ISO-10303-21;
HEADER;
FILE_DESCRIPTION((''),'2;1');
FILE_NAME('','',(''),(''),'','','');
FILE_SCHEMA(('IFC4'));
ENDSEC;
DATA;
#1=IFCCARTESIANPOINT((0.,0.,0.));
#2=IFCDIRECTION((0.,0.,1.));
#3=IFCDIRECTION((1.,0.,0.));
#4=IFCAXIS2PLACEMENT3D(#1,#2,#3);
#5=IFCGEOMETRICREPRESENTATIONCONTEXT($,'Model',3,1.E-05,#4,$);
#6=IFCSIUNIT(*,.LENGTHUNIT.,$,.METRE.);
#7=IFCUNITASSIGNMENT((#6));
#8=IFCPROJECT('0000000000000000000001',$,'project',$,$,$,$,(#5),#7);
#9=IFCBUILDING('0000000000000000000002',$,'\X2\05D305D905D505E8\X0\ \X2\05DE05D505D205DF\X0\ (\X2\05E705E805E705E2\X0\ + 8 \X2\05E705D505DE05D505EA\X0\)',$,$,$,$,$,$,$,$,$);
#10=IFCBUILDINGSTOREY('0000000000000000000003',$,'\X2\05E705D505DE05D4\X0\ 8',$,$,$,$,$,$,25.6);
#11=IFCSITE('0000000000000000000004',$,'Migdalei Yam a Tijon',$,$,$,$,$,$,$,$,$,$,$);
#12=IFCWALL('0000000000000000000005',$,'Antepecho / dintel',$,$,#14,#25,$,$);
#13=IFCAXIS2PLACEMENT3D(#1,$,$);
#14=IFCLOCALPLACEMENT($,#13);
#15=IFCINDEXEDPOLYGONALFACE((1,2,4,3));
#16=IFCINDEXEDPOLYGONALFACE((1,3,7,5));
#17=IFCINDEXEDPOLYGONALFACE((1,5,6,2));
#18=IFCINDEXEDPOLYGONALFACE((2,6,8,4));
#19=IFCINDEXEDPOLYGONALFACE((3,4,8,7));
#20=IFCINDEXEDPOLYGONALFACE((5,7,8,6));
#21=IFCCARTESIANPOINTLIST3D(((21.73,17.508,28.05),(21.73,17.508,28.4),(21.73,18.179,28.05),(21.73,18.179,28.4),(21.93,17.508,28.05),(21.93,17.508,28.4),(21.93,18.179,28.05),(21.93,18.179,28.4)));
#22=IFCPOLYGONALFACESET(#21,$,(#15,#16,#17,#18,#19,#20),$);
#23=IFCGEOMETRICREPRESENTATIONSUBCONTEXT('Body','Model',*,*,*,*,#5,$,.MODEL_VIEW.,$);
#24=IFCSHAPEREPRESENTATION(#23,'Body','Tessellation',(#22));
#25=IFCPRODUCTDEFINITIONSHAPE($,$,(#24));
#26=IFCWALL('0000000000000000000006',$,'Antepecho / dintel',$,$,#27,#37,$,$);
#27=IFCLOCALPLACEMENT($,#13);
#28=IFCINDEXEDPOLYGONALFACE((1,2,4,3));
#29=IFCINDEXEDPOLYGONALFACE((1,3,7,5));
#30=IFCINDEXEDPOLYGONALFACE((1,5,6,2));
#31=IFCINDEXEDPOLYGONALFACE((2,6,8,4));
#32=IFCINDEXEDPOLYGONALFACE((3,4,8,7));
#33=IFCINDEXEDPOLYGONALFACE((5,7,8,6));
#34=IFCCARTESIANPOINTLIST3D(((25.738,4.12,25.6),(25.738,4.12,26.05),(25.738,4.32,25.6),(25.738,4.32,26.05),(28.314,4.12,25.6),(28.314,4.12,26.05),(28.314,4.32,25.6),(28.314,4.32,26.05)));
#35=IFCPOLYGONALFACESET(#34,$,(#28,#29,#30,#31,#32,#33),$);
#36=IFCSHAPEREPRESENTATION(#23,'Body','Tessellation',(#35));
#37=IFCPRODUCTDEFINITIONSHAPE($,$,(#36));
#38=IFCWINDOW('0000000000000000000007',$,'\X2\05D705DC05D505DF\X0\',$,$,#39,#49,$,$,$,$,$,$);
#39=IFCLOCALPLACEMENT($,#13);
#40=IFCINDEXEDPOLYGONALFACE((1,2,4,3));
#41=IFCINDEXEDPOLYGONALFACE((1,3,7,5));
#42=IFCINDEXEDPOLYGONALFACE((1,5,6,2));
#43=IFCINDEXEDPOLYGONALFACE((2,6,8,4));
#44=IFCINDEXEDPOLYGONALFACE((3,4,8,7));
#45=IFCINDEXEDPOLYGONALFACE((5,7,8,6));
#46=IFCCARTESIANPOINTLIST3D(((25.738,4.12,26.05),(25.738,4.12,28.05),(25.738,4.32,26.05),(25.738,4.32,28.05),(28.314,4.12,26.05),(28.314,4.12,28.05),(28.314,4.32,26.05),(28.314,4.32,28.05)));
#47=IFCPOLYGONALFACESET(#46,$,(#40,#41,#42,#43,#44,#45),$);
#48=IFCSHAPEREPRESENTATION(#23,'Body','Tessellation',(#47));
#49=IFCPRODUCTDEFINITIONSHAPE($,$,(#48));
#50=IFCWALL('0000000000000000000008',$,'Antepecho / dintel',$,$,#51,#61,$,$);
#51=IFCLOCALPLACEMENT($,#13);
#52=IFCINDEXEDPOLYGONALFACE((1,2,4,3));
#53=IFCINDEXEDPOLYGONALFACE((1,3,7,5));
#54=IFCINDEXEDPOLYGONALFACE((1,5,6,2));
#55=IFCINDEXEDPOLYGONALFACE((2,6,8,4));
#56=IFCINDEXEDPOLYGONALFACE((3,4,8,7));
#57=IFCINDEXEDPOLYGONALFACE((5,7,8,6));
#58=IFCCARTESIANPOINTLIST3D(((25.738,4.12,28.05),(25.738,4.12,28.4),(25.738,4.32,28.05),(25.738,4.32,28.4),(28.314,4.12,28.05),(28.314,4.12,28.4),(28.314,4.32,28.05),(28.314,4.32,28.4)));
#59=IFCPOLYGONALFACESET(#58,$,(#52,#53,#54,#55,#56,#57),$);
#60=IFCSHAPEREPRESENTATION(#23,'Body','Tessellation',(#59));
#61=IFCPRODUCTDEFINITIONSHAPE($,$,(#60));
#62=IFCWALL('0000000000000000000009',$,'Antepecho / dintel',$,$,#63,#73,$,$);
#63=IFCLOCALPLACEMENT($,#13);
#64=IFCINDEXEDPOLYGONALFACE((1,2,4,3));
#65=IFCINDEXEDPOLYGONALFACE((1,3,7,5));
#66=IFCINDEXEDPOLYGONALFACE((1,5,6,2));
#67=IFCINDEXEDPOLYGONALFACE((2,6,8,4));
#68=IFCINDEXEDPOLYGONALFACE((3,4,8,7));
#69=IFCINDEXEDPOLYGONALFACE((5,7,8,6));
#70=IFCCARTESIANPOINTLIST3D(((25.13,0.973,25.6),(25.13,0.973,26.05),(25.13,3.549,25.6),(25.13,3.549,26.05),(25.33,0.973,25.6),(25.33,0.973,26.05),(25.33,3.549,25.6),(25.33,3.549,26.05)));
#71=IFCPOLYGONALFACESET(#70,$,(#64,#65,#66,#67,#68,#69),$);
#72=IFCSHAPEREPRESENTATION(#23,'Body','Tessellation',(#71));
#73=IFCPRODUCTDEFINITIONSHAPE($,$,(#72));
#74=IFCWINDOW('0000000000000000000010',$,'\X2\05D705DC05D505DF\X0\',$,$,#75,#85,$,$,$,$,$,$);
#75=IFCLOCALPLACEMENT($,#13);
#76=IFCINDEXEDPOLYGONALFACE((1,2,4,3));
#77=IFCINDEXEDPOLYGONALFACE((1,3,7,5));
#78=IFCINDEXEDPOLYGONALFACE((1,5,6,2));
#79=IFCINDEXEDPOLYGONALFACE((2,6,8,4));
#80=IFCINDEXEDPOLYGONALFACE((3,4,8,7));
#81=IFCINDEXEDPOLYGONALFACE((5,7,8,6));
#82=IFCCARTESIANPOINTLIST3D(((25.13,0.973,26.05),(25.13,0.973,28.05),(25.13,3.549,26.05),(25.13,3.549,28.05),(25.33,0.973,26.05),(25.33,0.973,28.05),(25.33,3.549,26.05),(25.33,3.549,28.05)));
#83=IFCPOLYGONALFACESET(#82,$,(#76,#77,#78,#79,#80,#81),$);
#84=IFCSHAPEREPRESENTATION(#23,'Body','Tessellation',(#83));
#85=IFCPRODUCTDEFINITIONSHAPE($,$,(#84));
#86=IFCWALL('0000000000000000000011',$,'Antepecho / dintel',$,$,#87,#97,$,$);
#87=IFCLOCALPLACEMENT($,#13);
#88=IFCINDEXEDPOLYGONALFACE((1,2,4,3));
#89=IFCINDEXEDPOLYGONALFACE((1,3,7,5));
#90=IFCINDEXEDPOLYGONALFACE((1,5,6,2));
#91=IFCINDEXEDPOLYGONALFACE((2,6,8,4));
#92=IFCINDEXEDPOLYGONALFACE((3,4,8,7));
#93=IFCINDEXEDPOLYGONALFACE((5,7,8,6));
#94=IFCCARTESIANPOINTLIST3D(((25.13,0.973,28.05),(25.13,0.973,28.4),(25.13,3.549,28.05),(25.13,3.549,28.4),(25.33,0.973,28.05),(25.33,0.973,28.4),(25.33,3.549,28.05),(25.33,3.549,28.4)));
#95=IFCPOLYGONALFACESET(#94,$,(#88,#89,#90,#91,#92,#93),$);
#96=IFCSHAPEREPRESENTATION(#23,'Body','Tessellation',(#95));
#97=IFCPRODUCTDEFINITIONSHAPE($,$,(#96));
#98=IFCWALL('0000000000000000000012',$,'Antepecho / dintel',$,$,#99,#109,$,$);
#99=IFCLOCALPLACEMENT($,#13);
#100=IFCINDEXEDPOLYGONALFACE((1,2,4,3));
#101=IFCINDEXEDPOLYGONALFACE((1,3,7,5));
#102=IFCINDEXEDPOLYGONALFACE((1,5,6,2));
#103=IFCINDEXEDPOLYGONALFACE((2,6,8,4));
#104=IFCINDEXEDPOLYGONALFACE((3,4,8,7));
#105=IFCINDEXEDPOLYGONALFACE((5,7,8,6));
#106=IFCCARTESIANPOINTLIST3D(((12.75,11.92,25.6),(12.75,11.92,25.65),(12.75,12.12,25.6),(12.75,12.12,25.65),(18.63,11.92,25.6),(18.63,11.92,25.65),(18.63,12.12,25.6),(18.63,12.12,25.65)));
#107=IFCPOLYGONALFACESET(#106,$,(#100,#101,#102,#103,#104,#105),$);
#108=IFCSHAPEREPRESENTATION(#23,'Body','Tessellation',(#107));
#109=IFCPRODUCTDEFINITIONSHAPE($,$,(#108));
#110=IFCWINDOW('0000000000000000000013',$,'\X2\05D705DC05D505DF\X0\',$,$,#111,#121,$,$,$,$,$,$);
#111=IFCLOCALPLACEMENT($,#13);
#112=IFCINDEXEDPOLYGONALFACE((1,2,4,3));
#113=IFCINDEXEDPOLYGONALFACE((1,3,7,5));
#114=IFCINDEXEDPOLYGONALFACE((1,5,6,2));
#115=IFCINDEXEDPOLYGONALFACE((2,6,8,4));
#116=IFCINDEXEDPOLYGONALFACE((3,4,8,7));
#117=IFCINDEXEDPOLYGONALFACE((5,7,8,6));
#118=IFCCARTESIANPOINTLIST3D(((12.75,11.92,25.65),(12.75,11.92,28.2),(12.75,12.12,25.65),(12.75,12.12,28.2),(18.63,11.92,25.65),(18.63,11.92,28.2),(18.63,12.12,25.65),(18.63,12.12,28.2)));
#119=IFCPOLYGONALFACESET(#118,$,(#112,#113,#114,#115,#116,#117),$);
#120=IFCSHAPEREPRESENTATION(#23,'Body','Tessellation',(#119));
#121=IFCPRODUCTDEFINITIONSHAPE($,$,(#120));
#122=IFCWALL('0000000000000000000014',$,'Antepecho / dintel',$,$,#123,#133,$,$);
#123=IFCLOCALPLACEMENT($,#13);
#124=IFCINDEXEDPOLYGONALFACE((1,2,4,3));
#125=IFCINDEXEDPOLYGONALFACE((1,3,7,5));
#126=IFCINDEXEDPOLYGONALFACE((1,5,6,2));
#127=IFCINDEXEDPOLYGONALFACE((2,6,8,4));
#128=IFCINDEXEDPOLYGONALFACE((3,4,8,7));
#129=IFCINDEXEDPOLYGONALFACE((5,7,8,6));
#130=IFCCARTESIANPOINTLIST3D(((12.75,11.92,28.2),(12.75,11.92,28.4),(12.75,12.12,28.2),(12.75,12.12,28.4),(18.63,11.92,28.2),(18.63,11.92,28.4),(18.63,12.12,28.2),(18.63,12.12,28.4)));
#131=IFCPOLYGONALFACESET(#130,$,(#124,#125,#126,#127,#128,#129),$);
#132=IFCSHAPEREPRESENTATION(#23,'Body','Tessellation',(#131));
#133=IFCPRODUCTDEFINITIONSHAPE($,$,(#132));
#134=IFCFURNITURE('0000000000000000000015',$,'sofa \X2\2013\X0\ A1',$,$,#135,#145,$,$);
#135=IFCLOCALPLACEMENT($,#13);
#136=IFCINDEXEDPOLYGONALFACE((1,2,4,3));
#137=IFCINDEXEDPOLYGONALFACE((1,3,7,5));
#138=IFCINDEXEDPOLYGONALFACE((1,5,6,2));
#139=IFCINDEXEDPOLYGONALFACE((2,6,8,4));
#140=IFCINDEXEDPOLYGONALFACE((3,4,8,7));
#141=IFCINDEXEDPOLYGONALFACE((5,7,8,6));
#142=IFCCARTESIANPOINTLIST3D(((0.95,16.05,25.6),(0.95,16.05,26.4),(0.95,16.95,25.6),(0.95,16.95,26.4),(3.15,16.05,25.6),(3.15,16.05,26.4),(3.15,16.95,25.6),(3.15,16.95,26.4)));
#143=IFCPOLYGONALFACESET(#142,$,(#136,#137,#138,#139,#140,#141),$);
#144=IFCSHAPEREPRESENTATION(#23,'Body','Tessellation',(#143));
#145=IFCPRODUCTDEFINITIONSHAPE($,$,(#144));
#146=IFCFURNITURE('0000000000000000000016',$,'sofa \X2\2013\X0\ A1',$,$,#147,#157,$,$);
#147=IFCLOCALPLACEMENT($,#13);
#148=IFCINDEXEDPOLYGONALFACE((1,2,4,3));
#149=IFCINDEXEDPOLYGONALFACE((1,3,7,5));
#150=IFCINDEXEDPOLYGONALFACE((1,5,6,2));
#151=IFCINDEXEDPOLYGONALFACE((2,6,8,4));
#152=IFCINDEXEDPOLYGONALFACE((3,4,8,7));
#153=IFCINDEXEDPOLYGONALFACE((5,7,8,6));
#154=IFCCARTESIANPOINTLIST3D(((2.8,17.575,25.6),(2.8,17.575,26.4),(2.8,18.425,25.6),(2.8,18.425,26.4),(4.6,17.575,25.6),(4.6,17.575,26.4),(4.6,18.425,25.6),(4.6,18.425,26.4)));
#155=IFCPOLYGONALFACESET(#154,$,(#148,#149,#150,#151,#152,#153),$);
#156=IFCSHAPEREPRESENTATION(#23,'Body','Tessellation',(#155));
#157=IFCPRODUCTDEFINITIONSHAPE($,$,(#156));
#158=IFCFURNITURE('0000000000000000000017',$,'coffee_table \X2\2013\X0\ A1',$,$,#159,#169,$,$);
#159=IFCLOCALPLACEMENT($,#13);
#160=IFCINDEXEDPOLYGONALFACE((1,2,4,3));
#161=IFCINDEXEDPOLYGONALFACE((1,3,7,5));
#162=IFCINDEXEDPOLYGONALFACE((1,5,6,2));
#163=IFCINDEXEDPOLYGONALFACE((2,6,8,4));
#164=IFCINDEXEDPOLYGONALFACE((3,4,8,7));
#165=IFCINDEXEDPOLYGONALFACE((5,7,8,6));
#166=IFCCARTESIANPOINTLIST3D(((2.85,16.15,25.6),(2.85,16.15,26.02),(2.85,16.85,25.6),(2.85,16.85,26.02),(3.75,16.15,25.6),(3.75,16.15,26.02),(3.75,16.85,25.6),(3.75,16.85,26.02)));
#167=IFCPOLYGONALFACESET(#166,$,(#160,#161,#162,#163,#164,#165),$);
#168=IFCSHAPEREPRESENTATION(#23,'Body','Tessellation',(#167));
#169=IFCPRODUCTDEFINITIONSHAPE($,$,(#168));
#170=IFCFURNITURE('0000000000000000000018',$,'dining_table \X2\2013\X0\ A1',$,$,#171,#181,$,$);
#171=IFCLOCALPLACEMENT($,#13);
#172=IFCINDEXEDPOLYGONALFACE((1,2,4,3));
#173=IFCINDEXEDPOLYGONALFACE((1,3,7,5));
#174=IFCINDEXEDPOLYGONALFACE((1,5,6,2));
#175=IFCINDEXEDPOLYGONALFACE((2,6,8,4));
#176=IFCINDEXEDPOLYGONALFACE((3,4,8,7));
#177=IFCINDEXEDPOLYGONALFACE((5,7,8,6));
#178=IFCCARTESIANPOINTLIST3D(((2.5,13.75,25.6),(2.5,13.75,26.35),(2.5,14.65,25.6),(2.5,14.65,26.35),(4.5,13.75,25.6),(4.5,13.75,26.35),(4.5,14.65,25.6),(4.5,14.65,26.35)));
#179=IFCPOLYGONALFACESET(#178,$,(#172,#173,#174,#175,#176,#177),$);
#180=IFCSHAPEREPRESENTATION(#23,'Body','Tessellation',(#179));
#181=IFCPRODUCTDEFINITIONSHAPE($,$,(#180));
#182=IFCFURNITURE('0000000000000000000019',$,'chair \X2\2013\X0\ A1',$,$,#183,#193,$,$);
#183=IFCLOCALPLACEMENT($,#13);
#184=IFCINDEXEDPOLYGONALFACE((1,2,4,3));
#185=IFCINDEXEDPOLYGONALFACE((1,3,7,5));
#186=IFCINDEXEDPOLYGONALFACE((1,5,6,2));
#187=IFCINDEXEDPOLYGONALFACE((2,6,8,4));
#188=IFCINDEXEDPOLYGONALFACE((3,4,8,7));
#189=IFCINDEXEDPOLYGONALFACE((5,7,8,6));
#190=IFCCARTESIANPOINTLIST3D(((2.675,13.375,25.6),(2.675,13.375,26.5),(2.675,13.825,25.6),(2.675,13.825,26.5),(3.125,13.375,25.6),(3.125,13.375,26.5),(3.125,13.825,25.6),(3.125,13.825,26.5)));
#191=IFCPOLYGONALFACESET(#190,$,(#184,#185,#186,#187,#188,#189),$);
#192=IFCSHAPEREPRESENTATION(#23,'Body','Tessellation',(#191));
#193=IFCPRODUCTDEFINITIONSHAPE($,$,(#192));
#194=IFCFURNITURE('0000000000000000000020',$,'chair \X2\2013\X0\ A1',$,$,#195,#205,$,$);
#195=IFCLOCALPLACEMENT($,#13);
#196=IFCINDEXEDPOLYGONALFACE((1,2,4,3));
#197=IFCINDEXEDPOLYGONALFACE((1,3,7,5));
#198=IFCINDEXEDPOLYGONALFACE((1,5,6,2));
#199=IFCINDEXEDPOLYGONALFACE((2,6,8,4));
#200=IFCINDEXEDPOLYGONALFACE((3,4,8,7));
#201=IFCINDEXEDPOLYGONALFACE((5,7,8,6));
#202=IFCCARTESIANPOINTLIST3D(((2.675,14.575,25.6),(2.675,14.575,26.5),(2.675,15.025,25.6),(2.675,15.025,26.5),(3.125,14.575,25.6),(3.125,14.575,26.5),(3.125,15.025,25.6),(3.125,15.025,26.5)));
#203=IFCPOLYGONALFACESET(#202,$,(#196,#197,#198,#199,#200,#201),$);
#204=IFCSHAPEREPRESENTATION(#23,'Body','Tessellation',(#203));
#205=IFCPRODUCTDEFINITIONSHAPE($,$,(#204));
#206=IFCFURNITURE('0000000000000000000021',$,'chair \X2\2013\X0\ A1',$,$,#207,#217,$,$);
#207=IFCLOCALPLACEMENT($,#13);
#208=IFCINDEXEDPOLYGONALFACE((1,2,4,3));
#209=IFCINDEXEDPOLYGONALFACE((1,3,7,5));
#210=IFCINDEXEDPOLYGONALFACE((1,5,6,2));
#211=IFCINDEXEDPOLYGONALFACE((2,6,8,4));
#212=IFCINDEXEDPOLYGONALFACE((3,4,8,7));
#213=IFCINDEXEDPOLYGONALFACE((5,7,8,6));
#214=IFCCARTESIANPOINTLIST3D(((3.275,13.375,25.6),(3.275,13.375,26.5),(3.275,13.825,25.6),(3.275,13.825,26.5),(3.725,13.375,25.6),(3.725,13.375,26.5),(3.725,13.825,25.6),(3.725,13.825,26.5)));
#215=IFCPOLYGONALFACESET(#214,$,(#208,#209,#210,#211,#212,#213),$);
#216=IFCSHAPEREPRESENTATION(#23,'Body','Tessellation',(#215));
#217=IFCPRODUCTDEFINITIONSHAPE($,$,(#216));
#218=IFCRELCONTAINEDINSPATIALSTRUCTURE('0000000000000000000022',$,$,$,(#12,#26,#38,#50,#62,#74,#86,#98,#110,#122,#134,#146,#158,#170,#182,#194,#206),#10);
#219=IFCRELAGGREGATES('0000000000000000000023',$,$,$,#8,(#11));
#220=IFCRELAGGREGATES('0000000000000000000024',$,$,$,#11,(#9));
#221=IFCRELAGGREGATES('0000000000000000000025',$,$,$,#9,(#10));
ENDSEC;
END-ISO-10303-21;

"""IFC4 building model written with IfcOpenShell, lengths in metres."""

from ifc_helpers import new_model, si_unit, frame, origin_with_axes, context, subcontext, project, spatial, line, indexed_curve, outline, extrude, element, save


model = new_model("IFC4")

# Units and contexts
model_context = context("Model", 3, precision=1e-05, world=origin_with_axes())
body_context = subcontext(model_context, "Body", "Model", "MODEL_VIEW")
ifc_project = project(units=[si_unit("LENGTHUNIT", "METRE")], contexts=[model_context])

# Site, building, storey
site = spatial("IfcSite", under=ifc_project, Name="Migdalei Yam a Tijon")
building = spatial("IfcBuilding", under=site, Name="דיור מוגן (קרקע + 8 קומות)")
storey = spatial("IfcBuildingStorey", under=building, Name="קומה 8", Elevation=25.6)

# Walls
element("IfcWall", 1, inside=storey, Name="Antepecho / dintel", context=body_context, shape_type="SweptSolid", body=[
    extrude(outline(indexed_curve([(0.0, 0.0), (0.2, 0.0), (0.2, 0.671), (0.0, 0.671)], segments=[line(1, 2, 3, 4, 1)])), frame((21.73, 17.508, 28.05), z_axis=(0.0, 0.0, 1.0), x_axis=(1.0, 0.0, 0.0)), (0.0, 0.0, 1.0), 0.35),
])
element("IfcWall", 2, inside=storey, Name="Antepecho / dintel", context=body_context, shape_type="SweptSolid", body=[
    extrude(outline(indexed_curve([(0.0, 0.0), (2.576, 0.0), (2.576, 0.2), (0.0, 0.2)], segments=[line(1, 2, 3, 4, 1)])), frame((25.738, 4.12, 25.6), z_axis=(0.0, 0.0, 1.0), x_axis=(1.0, 0.0, 0.0)), (0.0, 0.0, 1.0), 0.45),
])

# Window
element("IfcWindow", 3, inside=storey, Name="חלון", context=body_context, shape_type="SweptSolid", body=[
    extrude(outline(indexed_curve([(0.0, 0.0), (2.576, 0.0), (2.576, 0.2), (0.0, 0.2)], segments=[line(1, 2, 3, 4, 1)])), frame((25.738, 4.12, 26.05), z_axis=(0.0, 0.0, 1.0), x_axis=(1.0, 0.0, 0.0)), (0.0, 0.0, 1.0), 2.0),
])

# Walls
element("IfcWall", 4, inside=storey, Name="Antepecho / dintel", context=body_context, shape_type="SweptSolid", body=[
    extrude(outline(indexed_curve([(0.0, 0.0), (2.576, 0.0), (2.576, 0.2), (0.0, 0.2)], segments=[line(1, 2, 3, 4, 1)])), frame((25.738, 4.12, 28.05), z_axis=(0.0, 0.0, 1.0), x_axis=(1.0, 0.0, 0.0)), (0.0, 0.0, 1.0), 0.35),
])
element("IfcWall", 5, inside=storey, Name="Antepecho / dintel", context=body_context, shape_type="SweptSolid", body=[
    extrude(outline(indexed_curve([(0.0, 0.0), (0.2, 0.0), (0.2, 2.576), (0.0, 2.576)], segments=[line(1, 2, 3, 4, 1)])), frame((25.13, 0.973, 25.6), z_axis=(0.0, 0.0, 1.0), x_axis=(1.0, 0.0, 0.0)), (0.0, 0.0, 1.0), 0.45),
])

# Window
element("IfcWindow", 6, inside=storey, Name="חלון", context=body_context, shape_type="SweptSolid", body=[
    extrude(outline(indexed_curve([(0.0, 0.0), (0.2, 0.0), (0.2, 2.576), (0.0, 2.576)], segments=[line(1, 2, 3, 4, 1)])), frame((25.13, 0.973, 26.05), z_axis=(0.0, 0.0, 1.0), x_axis=(1.0, 0.0, 0.0)), (0.0, 0.0, 1.0), 2.0),
])

# Walls
element("IfcWall", 7, inside=storey, Name="Antepecho / dintel", context=body_context, shape_type="SweptSolid", body=[
    extrude(outline(indexed_curve([(0.0, 0.0), (0.2, 0.0), (0.2, 2.576), (0.0, 2.576)], segments=[line(1, 2, 3, 4, 1)])), frame((25.13, 0.973, 28.05), z_axis=(0.0, 0.0, 1.0), x_axis=(1.0, 0.0, 0.0)), (0.0, 0.0, 1.0), 0.35),
])
element("IfcWall", 8, inside=storey, Name="Antepecho / dintel", context=body_context, shape_type="SweptSolid", body=[
    extrude(outline(indexed_curve([(0.0, 0.0), (5.88, 0.0), (5.88, 0.2), (0.0, 0.2)], segments=[line(1, 2, 3, 4, 1)])), frame((12.75, 11.92, 25.6), z_axis=(0.0, 0.0, 1.0), x_axis=(1.0, 0.0, 0.0)), (0.0, 0.0, 1.0), 0.05),
])

# Window
element("IfcWindow", 9, inside=storey, Name="חלון", context=body_context, shape_type="SweptSolid", body=[
    extrude(outline(indexed_curve([(0.0, 0.0), (5.88, 0.0), (5.88, 0.2), (0.0, 0.2)], segments=[line(1, 2, 3, 4, 1)])), frame((12.75, 11.92, 25.65), z_axis=(0.0, 0.0, 1.0), x_axis=(1.0, 0.0, 0.0)), (0.0, 0.0, 1.0), 2.55),
])

# Wall
element("IfcWall", 10, inside=storey, Name="Antepecho / dintel", context=body_context, shape_type="SweptSolid", body=[
    extrude(outline(indexed_curve([(0.0, 0.0), (5.88, 0.0), (5.88, 0.2), (0.0, 0.2)], segments=[line(1, 2, 3, 4, 1)])), frame((12.75, 11.92, 28.2), z_axis=(0.0, 0.0, 1.0), x_axis=(1.0, 0.0, 0.0)), (0.0, 0.0, 1.0), 0.2),
])

# Furniture
element("IfcFurniture", 11, inside=storey, Name="sofa – A1", context=body_context, shape_type="SweptSolid", body=[
    extrude(outline(indexed_curve([(0.0, 0.0), (2.2, 0.0), (2.2, 0.9), (0.0, 0.9)], segments=[line(1, 2, 3, 4, 1)])), frame((0.95, 16.05, 25.6), z_axis=(0.0, 0.0, 1.0), x_axis=(1.0, 0.0, 0.0)), (0.0, 0.0, 1.0), 0.8),
])
element("IfcFurniture", 12, inside=storey, Name="sofa – A1", context=body_context, shape_type="SweptSolid", body=[
    extrude(outline(indexed_curve([(0.0, 0.0), (1.8, 0.0), (1.8, 0.85), (0.0, 0.85)], segments=[line(1, 2, 3, 4, 1)])), frame((2.8, 17.575, 25.6), z_axis=(0.0, 0.0, 1.0), x_axis=(1.0, 0.0, 0.0)), (0.0, 0.0, 1.0), 0.8),
])
element("IfcFurniture", 13, inside=storey, Name="coffee_table – A1", context=body_context, shape_type="SweptSolid", body=[
    extrude(outline(indexed_curve([(0.0, 0.0), (0.9, 0.0), (0.9, 0.7), (0.0, 0.7)], segments=[line(1, 2, 3, 4, 1)])), frame((2.85, 16.15, 25.6), z_axis=(0.0, 0.0, 1.0), x_axis=(1.0, 0.0, 0.0)), (0.0, 0.0, 1.0), 0.42),
])
element("IfcFurniture", 14, inside=storey, Name="dining_table – A1", context=body_context, shape_type="SweptSolid", body=[
    extrude(outline(indexed_curve([(0.0, 0.0), (2.0, 0.0), (2.0, 0.9), (0.0, 0.9)], segments=[line(1, 2, 3, 4, 1)])), frame((2.5, 13.75, 25.6), z_axis=(0.0, 0.0, 1.0), x_axis=(1.0, 0.0, 0.0)), (0.0, 0.0, 1.0), 0.75),
])
element("IfcFurniture", 15, inside=storey, Name="chair – A1", context=body_context, shape_type="SweptSolid", body=[
    extrude(outline(indexed_curve([(0.0, 0.0), (0.45, 0.0), (0.45, 0.45), (0.0, 0.45)], segments=[line(1, 2, 3, 4, 1)])), frame((2.675, 13.375, 25.6), z_axis=(0.0, 0.0, 1.0), x_axis=(1.0, 0.0, 0.0)), (0.0, 0.0, 1.0), 0.9),
])
element("IfcFurniture", 16, inside=storey, Name="chair – A1", context=body_context, shape_type="SweptSolid", body=[
    extrude(outline(indexed_curve([(0.0, 0.0), (0.45, 0.0), (0.45, 0.45), (0.0, 0.45)], segments=[line(1, 2, 3, 4, 1)])), frame((2.675, 14.575, 25.6), z_axis=(0.0, 0.0, 1.0), x_axis=(1.0, 0.0, 0.0)), (0.0, 0.0, 1.0), 0.9),
])
element("IfcFurniture", 17, inside=storey, Name="chair – A1", context=body_context, shape_type="SweptSolid", body=[
    extrude(outline(indexed_curve([(0.0, 0.0), (0.45, 0.0), (0.45, 0.45), (0.0, 0.45)], segments=[line(1, 2, 3, 4, 1)])), frame((3.275, 13.375, 25.6), z_axis=(0.0, 0.0, 1.0), x_axis=(1.0, 0.0, 0.0)), (0.0, 0.0, 1.0), 0.9),
])

save(model, "model.ifc")
